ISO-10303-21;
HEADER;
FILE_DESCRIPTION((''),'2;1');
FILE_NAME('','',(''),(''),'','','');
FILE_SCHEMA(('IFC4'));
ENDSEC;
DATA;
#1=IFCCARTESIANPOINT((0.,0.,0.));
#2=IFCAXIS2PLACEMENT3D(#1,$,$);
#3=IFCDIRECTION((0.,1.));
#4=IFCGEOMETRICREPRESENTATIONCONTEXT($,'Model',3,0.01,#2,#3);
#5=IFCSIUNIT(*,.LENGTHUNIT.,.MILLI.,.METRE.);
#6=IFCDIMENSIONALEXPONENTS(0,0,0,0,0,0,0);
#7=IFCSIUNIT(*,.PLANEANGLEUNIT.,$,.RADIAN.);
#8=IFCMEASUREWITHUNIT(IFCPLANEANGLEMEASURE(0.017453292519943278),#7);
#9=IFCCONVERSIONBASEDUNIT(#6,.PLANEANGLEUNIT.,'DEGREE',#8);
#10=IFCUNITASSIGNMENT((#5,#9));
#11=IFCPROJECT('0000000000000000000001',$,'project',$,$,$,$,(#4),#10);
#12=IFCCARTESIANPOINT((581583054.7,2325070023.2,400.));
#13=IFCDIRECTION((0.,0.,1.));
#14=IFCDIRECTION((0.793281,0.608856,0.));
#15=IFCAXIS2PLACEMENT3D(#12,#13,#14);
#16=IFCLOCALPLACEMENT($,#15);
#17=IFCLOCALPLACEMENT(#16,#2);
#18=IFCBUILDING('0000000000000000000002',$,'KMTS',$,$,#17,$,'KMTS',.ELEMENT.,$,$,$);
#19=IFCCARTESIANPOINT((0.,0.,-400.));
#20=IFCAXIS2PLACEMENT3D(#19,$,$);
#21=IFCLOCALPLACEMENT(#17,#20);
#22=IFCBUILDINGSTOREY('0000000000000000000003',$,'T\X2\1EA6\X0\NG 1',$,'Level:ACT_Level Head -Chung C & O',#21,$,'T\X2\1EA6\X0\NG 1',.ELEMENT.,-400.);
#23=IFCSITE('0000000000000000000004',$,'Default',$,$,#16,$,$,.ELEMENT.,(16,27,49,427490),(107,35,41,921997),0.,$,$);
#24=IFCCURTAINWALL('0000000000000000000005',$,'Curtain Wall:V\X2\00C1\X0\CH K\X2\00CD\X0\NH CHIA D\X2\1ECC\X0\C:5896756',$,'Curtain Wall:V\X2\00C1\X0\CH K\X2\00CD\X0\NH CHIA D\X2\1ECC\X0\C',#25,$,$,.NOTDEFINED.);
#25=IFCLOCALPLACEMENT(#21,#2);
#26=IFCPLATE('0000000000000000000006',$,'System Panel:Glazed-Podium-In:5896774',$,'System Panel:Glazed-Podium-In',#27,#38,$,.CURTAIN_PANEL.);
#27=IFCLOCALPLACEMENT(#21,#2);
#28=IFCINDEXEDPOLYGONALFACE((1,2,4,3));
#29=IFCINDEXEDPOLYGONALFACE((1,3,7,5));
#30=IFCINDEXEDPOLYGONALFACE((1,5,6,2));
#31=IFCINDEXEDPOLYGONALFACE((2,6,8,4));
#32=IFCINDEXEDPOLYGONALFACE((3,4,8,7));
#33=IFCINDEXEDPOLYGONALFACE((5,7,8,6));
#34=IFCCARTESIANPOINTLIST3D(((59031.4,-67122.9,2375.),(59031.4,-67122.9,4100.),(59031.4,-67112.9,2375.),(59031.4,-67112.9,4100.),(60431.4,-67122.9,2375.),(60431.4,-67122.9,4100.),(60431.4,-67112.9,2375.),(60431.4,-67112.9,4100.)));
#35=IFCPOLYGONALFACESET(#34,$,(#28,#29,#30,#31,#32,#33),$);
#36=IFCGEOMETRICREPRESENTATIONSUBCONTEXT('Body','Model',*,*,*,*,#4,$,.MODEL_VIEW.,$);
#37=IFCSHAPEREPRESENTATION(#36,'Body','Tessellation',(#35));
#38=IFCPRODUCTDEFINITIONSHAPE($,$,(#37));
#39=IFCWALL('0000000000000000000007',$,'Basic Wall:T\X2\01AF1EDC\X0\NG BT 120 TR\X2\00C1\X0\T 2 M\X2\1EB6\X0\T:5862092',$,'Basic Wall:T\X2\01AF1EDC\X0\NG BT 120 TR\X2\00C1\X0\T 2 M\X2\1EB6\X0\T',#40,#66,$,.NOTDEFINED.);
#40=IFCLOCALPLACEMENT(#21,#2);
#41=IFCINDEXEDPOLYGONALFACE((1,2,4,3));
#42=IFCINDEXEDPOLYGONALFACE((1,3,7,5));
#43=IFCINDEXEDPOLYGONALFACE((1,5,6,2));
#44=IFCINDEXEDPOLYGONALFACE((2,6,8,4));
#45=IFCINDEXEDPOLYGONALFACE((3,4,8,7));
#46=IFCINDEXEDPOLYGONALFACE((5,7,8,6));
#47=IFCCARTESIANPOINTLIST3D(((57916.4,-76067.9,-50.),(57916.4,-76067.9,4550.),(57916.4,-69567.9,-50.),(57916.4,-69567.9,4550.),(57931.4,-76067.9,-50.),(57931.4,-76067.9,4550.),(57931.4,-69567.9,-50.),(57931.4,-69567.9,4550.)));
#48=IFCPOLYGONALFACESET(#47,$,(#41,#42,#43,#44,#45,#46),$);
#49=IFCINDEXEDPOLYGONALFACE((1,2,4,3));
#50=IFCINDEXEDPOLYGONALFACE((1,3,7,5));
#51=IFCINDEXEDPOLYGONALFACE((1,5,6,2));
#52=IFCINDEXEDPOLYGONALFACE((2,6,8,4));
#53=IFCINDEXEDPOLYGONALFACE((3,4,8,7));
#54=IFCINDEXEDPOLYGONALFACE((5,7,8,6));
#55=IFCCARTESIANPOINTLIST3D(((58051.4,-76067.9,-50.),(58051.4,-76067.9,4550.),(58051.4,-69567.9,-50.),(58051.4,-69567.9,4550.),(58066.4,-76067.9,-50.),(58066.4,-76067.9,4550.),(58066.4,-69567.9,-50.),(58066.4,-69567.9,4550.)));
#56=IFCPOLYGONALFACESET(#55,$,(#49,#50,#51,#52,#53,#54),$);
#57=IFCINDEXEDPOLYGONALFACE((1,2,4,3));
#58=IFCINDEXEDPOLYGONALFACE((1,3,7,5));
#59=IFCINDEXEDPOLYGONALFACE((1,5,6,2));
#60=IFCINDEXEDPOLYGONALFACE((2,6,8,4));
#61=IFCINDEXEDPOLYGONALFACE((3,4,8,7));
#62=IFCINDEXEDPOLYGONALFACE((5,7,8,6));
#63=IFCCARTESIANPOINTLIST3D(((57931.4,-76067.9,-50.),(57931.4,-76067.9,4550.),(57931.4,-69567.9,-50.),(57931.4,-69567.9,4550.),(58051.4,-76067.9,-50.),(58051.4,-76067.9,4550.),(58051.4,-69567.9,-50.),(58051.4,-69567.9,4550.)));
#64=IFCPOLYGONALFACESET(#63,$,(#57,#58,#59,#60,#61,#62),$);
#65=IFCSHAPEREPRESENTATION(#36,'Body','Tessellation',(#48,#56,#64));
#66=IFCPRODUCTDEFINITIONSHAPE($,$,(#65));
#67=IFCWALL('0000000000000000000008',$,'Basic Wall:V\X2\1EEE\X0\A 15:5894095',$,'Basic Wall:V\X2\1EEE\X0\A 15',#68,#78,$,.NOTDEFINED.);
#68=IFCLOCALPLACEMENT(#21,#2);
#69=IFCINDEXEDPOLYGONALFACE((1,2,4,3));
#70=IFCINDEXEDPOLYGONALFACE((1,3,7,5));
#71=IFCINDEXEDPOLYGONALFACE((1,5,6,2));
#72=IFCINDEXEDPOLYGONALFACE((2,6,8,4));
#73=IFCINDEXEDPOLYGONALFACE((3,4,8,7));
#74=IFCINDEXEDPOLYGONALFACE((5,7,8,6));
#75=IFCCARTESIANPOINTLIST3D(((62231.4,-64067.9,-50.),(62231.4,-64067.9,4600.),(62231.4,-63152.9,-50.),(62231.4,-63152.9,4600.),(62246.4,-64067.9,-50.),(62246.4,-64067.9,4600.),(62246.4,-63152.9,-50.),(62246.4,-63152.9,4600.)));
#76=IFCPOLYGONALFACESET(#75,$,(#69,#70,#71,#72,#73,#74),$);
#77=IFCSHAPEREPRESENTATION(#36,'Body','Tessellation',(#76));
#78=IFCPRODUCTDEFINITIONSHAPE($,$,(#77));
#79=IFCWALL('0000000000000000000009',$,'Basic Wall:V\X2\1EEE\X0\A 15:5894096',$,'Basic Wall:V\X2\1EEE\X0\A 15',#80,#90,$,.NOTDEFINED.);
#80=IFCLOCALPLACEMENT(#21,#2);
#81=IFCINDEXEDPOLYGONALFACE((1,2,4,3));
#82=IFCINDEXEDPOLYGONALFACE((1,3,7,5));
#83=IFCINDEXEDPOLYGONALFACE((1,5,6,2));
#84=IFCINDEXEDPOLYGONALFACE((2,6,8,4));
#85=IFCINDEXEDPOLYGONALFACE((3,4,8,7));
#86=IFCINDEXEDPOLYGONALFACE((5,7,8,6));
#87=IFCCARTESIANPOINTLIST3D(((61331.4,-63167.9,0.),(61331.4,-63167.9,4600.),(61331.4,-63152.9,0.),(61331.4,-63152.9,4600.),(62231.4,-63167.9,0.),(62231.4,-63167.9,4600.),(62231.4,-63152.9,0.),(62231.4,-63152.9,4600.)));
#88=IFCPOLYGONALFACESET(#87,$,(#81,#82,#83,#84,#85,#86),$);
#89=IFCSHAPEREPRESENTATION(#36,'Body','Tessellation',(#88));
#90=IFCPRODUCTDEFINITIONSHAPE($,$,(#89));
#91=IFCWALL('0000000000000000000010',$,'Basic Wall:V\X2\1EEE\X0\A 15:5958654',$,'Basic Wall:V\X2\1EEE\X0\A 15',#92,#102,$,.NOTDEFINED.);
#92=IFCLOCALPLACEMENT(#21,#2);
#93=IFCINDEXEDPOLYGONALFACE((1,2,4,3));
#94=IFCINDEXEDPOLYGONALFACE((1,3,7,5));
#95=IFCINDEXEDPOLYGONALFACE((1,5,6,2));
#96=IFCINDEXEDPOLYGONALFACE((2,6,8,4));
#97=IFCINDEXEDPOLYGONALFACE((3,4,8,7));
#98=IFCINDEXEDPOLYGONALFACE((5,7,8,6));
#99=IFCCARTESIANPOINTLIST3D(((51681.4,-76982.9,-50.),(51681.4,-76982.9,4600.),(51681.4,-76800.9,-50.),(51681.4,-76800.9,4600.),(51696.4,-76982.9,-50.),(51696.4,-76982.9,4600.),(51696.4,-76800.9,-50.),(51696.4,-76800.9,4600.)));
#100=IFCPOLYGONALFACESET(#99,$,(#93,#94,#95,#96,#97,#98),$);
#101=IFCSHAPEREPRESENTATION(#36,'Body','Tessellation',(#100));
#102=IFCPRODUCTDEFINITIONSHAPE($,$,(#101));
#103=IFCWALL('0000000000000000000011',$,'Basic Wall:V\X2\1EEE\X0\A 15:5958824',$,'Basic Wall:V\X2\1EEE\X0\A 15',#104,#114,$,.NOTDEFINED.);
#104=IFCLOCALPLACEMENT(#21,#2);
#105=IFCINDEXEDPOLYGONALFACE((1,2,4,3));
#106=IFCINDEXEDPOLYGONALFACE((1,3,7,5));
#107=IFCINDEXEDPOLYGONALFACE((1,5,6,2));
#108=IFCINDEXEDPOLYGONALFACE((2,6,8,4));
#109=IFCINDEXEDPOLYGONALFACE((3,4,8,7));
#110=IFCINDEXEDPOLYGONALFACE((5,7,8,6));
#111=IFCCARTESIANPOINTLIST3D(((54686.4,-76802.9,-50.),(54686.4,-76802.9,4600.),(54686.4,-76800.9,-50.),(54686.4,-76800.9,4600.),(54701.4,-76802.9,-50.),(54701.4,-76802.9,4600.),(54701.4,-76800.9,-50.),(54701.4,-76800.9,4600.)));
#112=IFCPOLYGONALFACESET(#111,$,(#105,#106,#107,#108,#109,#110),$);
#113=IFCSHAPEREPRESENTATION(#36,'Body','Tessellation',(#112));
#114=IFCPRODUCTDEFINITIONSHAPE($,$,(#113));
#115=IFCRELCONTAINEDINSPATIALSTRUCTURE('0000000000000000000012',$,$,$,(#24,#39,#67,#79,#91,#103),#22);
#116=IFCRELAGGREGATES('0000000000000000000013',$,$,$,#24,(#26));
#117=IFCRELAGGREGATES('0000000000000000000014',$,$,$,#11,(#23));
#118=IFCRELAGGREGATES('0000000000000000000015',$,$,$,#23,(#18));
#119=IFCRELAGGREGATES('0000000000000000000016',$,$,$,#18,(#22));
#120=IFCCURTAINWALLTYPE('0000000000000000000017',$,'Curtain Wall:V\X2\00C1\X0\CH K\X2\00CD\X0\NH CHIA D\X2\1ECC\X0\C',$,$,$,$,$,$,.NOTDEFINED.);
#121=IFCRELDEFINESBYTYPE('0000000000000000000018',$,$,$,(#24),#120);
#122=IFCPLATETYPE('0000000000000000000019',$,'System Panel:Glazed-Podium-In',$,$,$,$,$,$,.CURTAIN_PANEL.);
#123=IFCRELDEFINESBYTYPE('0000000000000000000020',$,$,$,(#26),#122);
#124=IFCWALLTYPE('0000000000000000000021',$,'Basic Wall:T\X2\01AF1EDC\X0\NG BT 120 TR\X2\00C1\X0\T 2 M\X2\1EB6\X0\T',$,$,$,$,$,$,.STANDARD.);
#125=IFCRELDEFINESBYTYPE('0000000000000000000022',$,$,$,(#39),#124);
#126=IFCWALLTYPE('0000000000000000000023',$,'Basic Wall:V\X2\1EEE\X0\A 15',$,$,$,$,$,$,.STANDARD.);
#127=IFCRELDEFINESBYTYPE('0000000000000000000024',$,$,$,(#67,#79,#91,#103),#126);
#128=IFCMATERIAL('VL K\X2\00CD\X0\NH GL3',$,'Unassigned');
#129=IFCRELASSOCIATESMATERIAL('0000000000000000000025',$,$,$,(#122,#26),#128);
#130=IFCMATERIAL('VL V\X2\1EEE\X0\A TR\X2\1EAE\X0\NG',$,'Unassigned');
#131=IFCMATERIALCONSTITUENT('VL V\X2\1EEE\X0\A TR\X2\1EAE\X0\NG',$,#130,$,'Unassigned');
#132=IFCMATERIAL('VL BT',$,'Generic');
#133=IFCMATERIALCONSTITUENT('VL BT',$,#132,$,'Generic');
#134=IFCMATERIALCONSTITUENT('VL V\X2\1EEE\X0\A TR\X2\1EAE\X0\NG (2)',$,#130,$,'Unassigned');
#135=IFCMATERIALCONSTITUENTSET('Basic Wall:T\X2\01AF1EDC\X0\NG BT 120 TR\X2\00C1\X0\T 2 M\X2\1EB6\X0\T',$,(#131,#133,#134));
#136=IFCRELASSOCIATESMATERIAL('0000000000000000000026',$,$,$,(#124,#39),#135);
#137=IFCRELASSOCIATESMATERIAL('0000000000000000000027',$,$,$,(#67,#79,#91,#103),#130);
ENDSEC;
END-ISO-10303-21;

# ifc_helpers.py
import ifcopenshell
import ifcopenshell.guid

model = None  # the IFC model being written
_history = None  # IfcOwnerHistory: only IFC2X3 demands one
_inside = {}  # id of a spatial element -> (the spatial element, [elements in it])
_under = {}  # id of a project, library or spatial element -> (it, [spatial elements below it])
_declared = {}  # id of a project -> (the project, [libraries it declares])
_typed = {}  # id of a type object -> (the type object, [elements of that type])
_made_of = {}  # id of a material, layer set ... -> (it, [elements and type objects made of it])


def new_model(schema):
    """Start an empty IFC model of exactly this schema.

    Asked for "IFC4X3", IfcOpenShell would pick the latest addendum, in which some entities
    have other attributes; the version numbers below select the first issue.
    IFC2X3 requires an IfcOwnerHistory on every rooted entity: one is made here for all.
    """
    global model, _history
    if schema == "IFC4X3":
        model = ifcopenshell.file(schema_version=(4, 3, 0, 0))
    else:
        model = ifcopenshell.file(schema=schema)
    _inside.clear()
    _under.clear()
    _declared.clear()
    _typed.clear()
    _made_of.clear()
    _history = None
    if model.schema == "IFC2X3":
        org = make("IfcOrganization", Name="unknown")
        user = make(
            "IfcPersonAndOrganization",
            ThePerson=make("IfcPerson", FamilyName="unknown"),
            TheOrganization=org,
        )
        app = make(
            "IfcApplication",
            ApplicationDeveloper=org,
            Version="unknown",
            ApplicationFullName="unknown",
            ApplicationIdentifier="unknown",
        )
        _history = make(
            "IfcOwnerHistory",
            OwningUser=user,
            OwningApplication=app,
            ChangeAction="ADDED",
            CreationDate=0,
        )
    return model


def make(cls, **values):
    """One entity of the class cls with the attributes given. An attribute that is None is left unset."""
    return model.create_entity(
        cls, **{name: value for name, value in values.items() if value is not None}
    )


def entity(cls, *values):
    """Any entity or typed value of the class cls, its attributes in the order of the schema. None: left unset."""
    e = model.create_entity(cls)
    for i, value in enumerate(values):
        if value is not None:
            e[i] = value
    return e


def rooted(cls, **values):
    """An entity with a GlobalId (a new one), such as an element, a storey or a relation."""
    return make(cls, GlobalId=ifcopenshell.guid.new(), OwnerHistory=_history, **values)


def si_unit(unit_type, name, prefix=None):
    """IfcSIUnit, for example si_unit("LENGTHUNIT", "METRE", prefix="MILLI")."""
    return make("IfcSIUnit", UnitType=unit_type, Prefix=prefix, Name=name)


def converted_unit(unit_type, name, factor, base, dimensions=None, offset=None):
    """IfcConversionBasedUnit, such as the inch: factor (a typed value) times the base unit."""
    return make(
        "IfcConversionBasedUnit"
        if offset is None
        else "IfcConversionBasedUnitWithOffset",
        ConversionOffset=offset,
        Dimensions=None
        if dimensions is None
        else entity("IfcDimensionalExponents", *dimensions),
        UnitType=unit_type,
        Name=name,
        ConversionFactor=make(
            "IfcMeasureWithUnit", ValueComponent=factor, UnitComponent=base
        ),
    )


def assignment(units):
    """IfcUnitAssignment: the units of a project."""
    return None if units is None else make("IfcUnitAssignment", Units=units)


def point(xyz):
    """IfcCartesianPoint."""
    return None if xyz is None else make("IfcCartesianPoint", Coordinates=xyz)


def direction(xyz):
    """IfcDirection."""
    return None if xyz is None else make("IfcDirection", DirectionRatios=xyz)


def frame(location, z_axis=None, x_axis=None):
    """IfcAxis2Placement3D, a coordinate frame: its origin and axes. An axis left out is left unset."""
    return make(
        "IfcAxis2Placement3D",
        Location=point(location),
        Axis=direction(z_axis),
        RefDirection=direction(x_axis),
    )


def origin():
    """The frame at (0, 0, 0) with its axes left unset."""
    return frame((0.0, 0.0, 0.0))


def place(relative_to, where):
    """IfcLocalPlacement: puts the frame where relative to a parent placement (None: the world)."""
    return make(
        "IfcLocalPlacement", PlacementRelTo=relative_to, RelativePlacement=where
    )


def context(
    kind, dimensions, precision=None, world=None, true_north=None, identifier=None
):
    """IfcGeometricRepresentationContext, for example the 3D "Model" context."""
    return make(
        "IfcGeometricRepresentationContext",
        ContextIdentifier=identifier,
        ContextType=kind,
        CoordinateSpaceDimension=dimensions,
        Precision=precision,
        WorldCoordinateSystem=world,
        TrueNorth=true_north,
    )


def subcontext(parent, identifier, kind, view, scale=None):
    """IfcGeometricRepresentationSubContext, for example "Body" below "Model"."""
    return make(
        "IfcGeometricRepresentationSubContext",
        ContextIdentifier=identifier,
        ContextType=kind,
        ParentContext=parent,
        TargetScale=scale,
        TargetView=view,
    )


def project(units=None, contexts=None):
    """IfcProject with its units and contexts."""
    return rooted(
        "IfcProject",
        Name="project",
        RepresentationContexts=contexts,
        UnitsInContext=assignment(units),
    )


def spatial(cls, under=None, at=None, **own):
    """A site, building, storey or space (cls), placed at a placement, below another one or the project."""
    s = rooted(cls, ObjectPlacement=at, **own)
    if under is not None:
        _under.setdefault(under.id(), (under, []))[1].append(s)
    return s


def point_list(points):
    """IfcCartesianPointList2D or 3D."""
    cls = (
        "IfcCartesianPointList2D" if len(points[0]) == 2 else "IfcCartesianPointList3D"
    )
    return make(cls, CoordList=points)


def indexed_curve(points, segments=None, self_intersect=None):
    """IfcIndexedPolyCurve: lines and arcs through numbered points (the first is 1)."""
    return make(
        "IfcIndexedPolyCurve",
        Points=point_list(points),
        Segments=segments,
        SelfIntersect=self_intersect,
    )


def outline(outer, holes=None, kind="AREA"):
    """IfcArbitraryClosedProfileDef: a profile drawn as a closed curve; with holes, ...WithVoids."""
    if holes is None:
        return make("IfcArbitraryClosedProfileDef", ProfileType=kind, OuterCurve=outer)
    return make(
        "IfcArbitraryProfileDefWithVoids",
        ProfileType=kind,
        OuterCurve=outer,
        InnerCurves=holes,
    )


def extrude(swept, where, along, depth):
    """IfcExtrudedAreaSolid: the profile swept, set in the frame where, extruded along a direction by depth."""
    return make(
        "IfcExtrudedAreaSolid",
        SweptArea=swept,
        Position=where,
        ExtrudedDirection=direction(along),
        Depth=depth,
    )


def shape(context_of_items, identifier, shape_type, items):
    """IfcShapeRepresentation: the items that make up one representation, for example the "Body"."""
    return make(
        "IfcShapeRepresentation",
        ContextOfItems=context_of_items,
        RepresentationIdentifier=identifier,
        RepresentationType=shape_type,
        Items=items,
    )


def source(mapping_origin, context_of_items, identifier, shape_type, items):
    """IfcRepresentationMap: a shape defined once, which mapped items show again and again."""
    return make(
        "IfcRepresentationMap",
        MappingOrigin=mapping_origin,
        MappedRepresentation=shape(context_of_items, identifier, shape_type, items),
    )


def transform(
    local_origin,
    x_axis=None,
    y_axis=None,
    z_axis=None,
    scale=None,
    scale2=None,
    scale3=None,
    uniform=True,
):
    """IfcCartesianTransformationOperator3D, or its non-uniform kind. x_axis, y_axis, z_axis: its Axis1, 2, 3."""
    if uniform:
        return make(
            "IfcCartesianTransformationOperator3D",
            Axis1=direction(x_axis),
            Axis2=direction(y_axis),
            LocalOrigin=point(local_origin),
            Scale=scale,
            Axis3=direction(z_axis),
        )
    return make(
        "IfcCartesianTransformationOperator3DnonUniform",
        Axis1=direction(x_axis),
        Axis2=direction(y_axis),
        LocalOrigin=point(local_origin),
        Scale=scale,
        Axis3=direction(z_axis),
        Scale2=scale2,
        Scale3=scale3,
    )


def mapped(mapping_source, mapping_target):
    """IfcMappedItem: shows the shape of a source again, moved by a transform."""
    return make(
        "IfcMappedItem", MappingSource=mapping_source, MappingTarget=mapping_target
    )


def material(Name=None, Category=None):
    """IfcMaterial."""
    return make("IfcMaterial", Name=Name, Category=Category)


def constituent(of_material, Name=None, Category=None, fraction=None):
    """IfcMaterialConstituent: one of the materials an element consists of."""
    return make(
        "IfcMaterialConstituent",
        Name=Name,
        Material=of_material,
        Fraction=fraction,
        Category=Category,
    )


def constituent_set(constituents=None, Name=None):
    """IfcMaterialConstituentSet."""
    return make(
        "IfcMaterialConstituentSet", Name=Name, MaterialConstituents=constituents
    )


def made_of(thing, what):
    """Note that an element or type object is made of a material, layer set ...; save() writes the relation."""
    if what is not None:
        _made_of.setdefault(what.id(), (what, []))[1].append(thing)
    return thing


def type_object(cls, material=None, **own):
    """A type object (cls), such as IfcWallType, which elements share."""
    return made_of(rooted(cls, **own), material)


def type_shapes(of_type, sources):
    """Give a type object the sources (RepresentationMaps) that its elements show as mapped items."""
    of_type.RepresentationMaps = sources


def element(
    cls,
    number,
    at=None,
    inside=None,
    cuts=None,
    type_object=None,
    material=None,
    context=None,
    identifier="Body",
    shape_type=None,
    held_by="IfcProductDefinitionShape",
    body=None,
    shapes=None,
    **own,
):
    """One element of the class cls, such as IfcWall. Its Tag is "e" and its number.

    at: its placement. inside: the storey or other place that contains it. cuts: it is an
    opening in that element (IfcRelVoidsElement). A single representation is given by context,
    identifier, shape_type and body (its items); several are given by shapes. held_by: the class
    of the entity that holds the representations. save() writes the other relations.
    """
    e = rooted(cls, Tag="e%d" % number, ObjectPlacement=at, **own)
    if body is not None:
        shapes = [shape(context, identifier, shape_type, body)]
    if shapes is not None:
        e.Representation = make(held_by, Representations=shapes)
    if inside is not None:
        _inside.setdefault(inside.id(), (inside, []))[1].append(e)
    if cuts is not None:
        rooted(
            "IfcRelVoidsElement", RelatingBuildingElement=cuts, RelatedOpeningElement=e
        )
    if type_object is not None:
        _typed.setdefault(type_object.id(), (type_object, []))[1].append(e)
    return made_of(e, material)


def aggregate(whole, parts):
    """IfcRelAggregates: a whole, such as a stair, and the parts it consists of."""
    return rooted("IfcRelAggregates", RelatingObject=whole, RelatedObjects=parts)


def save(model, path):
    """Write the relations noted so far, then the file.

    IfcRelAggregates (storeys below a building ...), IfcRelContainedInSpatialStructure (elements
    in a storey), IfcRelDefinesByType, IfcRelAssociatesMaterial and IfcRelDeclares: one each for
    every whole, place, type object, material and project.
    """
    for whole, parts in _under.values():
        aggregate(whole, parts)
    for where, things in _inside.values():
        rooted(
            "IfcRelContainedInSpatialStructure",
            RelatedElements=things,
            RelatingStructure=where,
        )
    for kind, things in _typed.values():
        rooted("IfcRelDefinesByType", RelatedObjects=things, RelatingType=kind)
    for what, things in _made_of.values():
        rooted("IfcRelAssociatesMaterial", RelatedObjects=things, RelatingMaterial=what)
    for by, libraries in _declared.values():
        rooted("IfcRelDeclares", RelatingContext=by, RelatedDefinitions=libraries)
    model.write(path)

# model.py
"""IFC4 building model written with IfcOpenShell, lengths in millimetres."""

from ifc_helpers import new_model, entity, si_unit, converted_unit, direction, frame, origin, place, context, subcontext, project, spatial, indexed_curve, outline, extrude, source, transform, mapped, material, constituent, constituent_set, type_object, type_shapes, element, aggregate, save


model = new_model("IFC4")

# Units and contexts
model_context = context("Model", 3, precision=0.01, world=origin(), true_north=direction((0.0, 1.0)))
body_context = subcontext(model_context, "Body", "Model", "MODEL_VIEW")
ifc_project = project(units=[si_unit("LENGTHUNIT", "METRE", prefix="MILLI"), converted_unit("PLANEANGLEUNIT", "DEGREE", entity("IfcPlaneAngleMeasure", 0.017453292519943278), si_unit("PLANEANGLEUNIT", "RADIAN"), dimensions=[0, 0, 0, 0, 0, 0, 0])], contexts=[model_context])

# Site, building, storey
site_placement = place(None, frame((581583054.7, 2325070023.2, 400.0), z_axis=(0.0, 0.0, 1.0), x_axis=(0.793281, 0.608856, 0.0)))
site = spatial("IfcSite", under=ifc_project, at=site_placement, Name="Default", CompositionType="ELEMENT", RefLatitude=(16, 27, 49, 427490), RefLongitude=(107, 35, 41, 921997), RefElevation=0.0)
building_placement = place(site_placement, origin())
building = spatial("IfcBuilding", under=site, at=building_placement, Name="KMTS", LongName="KMTS", CompositionType="ELEMENT")
storey_placement = place(building_placement, frame((0.0, 0.0, -400.0)))
storey = spatial("IfcBuildingStorey", under=building, at=storey_placement, Name="TẦNG 1", ObjectType="Level:ACT_Level Head -Chung C & O", LongName="TẦNG 1", CompositionType="ELEMENT", Elevation=-400.0)

# Curtain wall
curtain_wall_type = type_object("IfcCurtainWallType", Name="Curtain Wall:VÁCH KÍNH CHIA DỌC", PredefinedType="NOTDEFINED")
curtain_wall_1_placement = place(storey_placement, frame((0.0, 0.0, 400.0)))
curtain_wall_1 = element("IfcCurtainWall", 1, at=curtain_wall_1_placement, inside=storey, type_object=curtain_wall_type, Name="Curtain Wall:VÁCH KÍNH CHIA DỌC:5896756", ObjectType="Curtain Wall:VÁCH KÍNH CHIA DỌC", PredefinedType="NOTDEFINED")

# Plate
ifc_material_1 = material(Name="VL KÍNH GL3", Category="Unassigned")
plate_type_1 = type_object("IfcPlateType", Name="System Panel:Glazed-Podium-In", PredefinedType="CURTAIN_PANEL", material=ifc_material_1)
shared_shape_1 = source(origin(), body_context, "Body", "SweptSolid", [
    extrude(outline(indexed_curve([(-5.0, -700.0), (5.0, -700.0), (5.0, 700.0), (-5.0, 700.0), (-5.0, -700.0)], self_intersect=False)), frame((0.0, 0.0, 0.0), z_axis=(0.0, 0.0, 1.0), x_axis=(0.0, 1.0, 0.0)), (0.0, 0.0, 1.0), 1725.0),
])
type_shapes(plate_type_1, [shared_shape_1])
plate_1_placement = place(curtain_wall_1_placement, frame((59731.4, -67117.9, 1975.0)))
plate_1 = element("IfcPlate", 2, at=plate_1_placement, type_object=plate_type_1, material=ifc_material_1, Name="System Panel:Glazed-Podium-In:5896774", ObjectType="System Panel:Glazed-Podium-In", PredefinedType="CURTAIN_PANEL", context=body_context, shape_type="MappedRepresentation", body=[
    mapped(shared_shape_1, transform((0.0, 0.0, 0.0), scale=1.0)),
])

# Walls
ifc_material_2 = material(Name="VL VỮA TRẮNG", Category="Unassigned")
ifc_constituent_1 = constituent(ifc_material_2, Name="VL VỮA TRẮNG", Category="Unassigned")
ifc_material_3 = material(Name="VL BT", Category="Generic")
ifc_constituent_2 = constituent(ifc_material_3, Name="VL BT", Category="Generic")
ifc_constituent_3 = constituent(ifc_material_2, Name="VL VỮA TRẮNG (2)", Category="Unassigned")
ifc_constituent_set_1 = constituent_set(constituents=[ifc_constituent_1, ifc_constituent_2, ifc_constituent_3], Name="Basic Wall:TƯỜNG BT 120 TRÁT 2 MẶT")
wall_type_1 = type_object("IfcWallType", Name="Basic Wall:TƯỜNG BT 120 TRÁT 2 MẶT", PredefinedType="STANDARD", material=ifc_constituent_set_1)
wall_1_placement = place(storey_placement, frame((57991.4, -69567.9, -50.0), z_axis=(0.0, 0.0, 1.0), x_axis=(0.0, -1.0, 0.0)))
element("IfcWall", 3, at=wall_1_placement, inside=storey, type_object=wall_type_1, material=ifc_constituent_set_1, Name="Basic Wall:TƯỜNG BT 120 TRÁT 2 MẶT:5862092", ObjectType="Basic Wall:TƯỜNG BT 120 TRÁT 2 MẶT", PredefinedType="NOTDEFINED", context=body_context, shape_type="SweptSolid", body=[
    extrude(outline(indexed_curve([(-7.5, -3250.0), (7.5, -3250.0), (7.5, 3250.0), (-7.5, 3250.0), (-7.5, -3250.0)], self_intersect=False)), frame((3250.0, -67.5, 0.0), z_axis=(0.0, 0.0, 1.0), x_axis=(0.0, 1.0, 0.0)), (0.0, 0.0, 1.0), 4600.0),
    extrude(outline(indexed_curve([(-7.5, -3250.0), (7.5, -3250.0), (7.5, 3250.0), (-7.5, 3250.0), (-7.5, -3250.0)], self_intersect=False)), frame((3250.0, 67.5, 0.0), z_axis=(0.0, 0.0, 1.0), x_axis=(0.0, -1.0, 0.0)), (0.0, 0.0, 1.0), 4600.0),
    extrude(outline(indexed_curve([(-3250.0, -60.0), (3250.0, -60.0), (3250.0, 60.0), (-3250.0, 60.0), (-3250.0, -60.0)], self_intersect=False)), frame((3250.0, 0.0, 0.0)), (0.0, 0.0, 1.0), 4600.0),
])
wall_type_2 = type_object("IfcWallType", Name="Basic Wall:VỮA 15", PredefinedType="STANDARD")
wall_2_placement = place(storey_placement, frame((62238.9, -64067.9, -50.0), z_axis=(0.0, 0.0, 1.0), x_axis=(0.0, 1.0, 0.0)))
element("IfcWall", 4, at=wall_2_placement, inside=storey, type_object=wall_type_2, material=ifc_material_2, Name="Basic Wall:VỮA 15:5894095", ObjectType="Basic Wall:VỮA 15", PredefinedType="NOTDEFINED", context=body_context, shape_type="SweptSolid", body=[
    extrude(outline(indexed_curve([(915.0, 7.5), (0.0, 7.5), (0.0, -7.5), (915.0, -7.5), (915.0, 7.5)], self_intersect=False)), origin(), (0.0, 0.0, 1.0), 4650.0),
])
wall_3_placement = place(storey_placement, frame((62231.4, -63160.4, 0.0), z_axis=(0.0, 0.0, 1.0), x_axis=(-1.0, 0.0, 0.0)))
element("IfcWall", 5, at=wall_3_placement, inside=storey, type_object=wall_type_2, material=ifc_material_2, Name="Basic Wall:VỮA 15:5894096", ObjectType="Basic Wall:VỮA 15", PredefinedType="NOTDEFINED", context=body_context, shape_type="SweptSolid", body=[
    extrude(outline(indexed_curve([(900.0, 7.5), (0.0, 7.5), (0.0, -7.5), (900.0, -7.5), (900.0, 7.5)], self_intersect=False)), origin(), (0.0, 0.0, 1.0), 4600.0),
])
wall_4_placement = place(storey_placement, frame((51688.9, -76982.9, -50.0), z_axis=(0.0, 0.0, 1.0), x_axis=(0.0, 1.0, 0.0)))
element("IfcWall", 6, at=wall_4_placement, inside=storey, type_object=wall_type_2, material=ifc_material_2, Name="Basic Wall:VỮA 15:5958654", ObjectType="Basic Wall:VỮA 15", PredefinedType="NOTDEFINED", context=body_context, shape_type="SweptSolid", body=[
    extrude(outline(indexed_curve([(182.0, 7.5), (0.0, 7.5), (0.0, -7.5), (182.0, -7.5), (182.0, 7.5)], self_intersect=False)), origin(), (0.0, 0.0, 1.0), 4650.0),
])
wall_5_placement = place(storey_placement, frame((54693.9, -76800.9, -50.0), z_axis=(0.0, 0.0, 1.0), x_axis=(0.0, -1.0, 0.0)))
element("IfcWall", 7, at=wall_5_placement, inside=storey, type_object=wall_type_2, material=ifc_material_2, Name="Basic Wall:VỮA 15:5958824", ObjectType="Basic Wall:VỮA 15", PredefinedType="NOTDEFINED", context=body_context, shape_type="SweptSolid", body=[
    extrude(outline(indexed_curve([(2.0, 7.5), (0.0, 7.5), (0.0, -7.5), (2.0, -7.5), (2.0, 7.5)], self_intersect=False)), origin(), (0.0, 0.0, 1.0), 4650.0),
])

aggregate(curtain_wall_1, [plate_1])

save(model, "model.ifc")
